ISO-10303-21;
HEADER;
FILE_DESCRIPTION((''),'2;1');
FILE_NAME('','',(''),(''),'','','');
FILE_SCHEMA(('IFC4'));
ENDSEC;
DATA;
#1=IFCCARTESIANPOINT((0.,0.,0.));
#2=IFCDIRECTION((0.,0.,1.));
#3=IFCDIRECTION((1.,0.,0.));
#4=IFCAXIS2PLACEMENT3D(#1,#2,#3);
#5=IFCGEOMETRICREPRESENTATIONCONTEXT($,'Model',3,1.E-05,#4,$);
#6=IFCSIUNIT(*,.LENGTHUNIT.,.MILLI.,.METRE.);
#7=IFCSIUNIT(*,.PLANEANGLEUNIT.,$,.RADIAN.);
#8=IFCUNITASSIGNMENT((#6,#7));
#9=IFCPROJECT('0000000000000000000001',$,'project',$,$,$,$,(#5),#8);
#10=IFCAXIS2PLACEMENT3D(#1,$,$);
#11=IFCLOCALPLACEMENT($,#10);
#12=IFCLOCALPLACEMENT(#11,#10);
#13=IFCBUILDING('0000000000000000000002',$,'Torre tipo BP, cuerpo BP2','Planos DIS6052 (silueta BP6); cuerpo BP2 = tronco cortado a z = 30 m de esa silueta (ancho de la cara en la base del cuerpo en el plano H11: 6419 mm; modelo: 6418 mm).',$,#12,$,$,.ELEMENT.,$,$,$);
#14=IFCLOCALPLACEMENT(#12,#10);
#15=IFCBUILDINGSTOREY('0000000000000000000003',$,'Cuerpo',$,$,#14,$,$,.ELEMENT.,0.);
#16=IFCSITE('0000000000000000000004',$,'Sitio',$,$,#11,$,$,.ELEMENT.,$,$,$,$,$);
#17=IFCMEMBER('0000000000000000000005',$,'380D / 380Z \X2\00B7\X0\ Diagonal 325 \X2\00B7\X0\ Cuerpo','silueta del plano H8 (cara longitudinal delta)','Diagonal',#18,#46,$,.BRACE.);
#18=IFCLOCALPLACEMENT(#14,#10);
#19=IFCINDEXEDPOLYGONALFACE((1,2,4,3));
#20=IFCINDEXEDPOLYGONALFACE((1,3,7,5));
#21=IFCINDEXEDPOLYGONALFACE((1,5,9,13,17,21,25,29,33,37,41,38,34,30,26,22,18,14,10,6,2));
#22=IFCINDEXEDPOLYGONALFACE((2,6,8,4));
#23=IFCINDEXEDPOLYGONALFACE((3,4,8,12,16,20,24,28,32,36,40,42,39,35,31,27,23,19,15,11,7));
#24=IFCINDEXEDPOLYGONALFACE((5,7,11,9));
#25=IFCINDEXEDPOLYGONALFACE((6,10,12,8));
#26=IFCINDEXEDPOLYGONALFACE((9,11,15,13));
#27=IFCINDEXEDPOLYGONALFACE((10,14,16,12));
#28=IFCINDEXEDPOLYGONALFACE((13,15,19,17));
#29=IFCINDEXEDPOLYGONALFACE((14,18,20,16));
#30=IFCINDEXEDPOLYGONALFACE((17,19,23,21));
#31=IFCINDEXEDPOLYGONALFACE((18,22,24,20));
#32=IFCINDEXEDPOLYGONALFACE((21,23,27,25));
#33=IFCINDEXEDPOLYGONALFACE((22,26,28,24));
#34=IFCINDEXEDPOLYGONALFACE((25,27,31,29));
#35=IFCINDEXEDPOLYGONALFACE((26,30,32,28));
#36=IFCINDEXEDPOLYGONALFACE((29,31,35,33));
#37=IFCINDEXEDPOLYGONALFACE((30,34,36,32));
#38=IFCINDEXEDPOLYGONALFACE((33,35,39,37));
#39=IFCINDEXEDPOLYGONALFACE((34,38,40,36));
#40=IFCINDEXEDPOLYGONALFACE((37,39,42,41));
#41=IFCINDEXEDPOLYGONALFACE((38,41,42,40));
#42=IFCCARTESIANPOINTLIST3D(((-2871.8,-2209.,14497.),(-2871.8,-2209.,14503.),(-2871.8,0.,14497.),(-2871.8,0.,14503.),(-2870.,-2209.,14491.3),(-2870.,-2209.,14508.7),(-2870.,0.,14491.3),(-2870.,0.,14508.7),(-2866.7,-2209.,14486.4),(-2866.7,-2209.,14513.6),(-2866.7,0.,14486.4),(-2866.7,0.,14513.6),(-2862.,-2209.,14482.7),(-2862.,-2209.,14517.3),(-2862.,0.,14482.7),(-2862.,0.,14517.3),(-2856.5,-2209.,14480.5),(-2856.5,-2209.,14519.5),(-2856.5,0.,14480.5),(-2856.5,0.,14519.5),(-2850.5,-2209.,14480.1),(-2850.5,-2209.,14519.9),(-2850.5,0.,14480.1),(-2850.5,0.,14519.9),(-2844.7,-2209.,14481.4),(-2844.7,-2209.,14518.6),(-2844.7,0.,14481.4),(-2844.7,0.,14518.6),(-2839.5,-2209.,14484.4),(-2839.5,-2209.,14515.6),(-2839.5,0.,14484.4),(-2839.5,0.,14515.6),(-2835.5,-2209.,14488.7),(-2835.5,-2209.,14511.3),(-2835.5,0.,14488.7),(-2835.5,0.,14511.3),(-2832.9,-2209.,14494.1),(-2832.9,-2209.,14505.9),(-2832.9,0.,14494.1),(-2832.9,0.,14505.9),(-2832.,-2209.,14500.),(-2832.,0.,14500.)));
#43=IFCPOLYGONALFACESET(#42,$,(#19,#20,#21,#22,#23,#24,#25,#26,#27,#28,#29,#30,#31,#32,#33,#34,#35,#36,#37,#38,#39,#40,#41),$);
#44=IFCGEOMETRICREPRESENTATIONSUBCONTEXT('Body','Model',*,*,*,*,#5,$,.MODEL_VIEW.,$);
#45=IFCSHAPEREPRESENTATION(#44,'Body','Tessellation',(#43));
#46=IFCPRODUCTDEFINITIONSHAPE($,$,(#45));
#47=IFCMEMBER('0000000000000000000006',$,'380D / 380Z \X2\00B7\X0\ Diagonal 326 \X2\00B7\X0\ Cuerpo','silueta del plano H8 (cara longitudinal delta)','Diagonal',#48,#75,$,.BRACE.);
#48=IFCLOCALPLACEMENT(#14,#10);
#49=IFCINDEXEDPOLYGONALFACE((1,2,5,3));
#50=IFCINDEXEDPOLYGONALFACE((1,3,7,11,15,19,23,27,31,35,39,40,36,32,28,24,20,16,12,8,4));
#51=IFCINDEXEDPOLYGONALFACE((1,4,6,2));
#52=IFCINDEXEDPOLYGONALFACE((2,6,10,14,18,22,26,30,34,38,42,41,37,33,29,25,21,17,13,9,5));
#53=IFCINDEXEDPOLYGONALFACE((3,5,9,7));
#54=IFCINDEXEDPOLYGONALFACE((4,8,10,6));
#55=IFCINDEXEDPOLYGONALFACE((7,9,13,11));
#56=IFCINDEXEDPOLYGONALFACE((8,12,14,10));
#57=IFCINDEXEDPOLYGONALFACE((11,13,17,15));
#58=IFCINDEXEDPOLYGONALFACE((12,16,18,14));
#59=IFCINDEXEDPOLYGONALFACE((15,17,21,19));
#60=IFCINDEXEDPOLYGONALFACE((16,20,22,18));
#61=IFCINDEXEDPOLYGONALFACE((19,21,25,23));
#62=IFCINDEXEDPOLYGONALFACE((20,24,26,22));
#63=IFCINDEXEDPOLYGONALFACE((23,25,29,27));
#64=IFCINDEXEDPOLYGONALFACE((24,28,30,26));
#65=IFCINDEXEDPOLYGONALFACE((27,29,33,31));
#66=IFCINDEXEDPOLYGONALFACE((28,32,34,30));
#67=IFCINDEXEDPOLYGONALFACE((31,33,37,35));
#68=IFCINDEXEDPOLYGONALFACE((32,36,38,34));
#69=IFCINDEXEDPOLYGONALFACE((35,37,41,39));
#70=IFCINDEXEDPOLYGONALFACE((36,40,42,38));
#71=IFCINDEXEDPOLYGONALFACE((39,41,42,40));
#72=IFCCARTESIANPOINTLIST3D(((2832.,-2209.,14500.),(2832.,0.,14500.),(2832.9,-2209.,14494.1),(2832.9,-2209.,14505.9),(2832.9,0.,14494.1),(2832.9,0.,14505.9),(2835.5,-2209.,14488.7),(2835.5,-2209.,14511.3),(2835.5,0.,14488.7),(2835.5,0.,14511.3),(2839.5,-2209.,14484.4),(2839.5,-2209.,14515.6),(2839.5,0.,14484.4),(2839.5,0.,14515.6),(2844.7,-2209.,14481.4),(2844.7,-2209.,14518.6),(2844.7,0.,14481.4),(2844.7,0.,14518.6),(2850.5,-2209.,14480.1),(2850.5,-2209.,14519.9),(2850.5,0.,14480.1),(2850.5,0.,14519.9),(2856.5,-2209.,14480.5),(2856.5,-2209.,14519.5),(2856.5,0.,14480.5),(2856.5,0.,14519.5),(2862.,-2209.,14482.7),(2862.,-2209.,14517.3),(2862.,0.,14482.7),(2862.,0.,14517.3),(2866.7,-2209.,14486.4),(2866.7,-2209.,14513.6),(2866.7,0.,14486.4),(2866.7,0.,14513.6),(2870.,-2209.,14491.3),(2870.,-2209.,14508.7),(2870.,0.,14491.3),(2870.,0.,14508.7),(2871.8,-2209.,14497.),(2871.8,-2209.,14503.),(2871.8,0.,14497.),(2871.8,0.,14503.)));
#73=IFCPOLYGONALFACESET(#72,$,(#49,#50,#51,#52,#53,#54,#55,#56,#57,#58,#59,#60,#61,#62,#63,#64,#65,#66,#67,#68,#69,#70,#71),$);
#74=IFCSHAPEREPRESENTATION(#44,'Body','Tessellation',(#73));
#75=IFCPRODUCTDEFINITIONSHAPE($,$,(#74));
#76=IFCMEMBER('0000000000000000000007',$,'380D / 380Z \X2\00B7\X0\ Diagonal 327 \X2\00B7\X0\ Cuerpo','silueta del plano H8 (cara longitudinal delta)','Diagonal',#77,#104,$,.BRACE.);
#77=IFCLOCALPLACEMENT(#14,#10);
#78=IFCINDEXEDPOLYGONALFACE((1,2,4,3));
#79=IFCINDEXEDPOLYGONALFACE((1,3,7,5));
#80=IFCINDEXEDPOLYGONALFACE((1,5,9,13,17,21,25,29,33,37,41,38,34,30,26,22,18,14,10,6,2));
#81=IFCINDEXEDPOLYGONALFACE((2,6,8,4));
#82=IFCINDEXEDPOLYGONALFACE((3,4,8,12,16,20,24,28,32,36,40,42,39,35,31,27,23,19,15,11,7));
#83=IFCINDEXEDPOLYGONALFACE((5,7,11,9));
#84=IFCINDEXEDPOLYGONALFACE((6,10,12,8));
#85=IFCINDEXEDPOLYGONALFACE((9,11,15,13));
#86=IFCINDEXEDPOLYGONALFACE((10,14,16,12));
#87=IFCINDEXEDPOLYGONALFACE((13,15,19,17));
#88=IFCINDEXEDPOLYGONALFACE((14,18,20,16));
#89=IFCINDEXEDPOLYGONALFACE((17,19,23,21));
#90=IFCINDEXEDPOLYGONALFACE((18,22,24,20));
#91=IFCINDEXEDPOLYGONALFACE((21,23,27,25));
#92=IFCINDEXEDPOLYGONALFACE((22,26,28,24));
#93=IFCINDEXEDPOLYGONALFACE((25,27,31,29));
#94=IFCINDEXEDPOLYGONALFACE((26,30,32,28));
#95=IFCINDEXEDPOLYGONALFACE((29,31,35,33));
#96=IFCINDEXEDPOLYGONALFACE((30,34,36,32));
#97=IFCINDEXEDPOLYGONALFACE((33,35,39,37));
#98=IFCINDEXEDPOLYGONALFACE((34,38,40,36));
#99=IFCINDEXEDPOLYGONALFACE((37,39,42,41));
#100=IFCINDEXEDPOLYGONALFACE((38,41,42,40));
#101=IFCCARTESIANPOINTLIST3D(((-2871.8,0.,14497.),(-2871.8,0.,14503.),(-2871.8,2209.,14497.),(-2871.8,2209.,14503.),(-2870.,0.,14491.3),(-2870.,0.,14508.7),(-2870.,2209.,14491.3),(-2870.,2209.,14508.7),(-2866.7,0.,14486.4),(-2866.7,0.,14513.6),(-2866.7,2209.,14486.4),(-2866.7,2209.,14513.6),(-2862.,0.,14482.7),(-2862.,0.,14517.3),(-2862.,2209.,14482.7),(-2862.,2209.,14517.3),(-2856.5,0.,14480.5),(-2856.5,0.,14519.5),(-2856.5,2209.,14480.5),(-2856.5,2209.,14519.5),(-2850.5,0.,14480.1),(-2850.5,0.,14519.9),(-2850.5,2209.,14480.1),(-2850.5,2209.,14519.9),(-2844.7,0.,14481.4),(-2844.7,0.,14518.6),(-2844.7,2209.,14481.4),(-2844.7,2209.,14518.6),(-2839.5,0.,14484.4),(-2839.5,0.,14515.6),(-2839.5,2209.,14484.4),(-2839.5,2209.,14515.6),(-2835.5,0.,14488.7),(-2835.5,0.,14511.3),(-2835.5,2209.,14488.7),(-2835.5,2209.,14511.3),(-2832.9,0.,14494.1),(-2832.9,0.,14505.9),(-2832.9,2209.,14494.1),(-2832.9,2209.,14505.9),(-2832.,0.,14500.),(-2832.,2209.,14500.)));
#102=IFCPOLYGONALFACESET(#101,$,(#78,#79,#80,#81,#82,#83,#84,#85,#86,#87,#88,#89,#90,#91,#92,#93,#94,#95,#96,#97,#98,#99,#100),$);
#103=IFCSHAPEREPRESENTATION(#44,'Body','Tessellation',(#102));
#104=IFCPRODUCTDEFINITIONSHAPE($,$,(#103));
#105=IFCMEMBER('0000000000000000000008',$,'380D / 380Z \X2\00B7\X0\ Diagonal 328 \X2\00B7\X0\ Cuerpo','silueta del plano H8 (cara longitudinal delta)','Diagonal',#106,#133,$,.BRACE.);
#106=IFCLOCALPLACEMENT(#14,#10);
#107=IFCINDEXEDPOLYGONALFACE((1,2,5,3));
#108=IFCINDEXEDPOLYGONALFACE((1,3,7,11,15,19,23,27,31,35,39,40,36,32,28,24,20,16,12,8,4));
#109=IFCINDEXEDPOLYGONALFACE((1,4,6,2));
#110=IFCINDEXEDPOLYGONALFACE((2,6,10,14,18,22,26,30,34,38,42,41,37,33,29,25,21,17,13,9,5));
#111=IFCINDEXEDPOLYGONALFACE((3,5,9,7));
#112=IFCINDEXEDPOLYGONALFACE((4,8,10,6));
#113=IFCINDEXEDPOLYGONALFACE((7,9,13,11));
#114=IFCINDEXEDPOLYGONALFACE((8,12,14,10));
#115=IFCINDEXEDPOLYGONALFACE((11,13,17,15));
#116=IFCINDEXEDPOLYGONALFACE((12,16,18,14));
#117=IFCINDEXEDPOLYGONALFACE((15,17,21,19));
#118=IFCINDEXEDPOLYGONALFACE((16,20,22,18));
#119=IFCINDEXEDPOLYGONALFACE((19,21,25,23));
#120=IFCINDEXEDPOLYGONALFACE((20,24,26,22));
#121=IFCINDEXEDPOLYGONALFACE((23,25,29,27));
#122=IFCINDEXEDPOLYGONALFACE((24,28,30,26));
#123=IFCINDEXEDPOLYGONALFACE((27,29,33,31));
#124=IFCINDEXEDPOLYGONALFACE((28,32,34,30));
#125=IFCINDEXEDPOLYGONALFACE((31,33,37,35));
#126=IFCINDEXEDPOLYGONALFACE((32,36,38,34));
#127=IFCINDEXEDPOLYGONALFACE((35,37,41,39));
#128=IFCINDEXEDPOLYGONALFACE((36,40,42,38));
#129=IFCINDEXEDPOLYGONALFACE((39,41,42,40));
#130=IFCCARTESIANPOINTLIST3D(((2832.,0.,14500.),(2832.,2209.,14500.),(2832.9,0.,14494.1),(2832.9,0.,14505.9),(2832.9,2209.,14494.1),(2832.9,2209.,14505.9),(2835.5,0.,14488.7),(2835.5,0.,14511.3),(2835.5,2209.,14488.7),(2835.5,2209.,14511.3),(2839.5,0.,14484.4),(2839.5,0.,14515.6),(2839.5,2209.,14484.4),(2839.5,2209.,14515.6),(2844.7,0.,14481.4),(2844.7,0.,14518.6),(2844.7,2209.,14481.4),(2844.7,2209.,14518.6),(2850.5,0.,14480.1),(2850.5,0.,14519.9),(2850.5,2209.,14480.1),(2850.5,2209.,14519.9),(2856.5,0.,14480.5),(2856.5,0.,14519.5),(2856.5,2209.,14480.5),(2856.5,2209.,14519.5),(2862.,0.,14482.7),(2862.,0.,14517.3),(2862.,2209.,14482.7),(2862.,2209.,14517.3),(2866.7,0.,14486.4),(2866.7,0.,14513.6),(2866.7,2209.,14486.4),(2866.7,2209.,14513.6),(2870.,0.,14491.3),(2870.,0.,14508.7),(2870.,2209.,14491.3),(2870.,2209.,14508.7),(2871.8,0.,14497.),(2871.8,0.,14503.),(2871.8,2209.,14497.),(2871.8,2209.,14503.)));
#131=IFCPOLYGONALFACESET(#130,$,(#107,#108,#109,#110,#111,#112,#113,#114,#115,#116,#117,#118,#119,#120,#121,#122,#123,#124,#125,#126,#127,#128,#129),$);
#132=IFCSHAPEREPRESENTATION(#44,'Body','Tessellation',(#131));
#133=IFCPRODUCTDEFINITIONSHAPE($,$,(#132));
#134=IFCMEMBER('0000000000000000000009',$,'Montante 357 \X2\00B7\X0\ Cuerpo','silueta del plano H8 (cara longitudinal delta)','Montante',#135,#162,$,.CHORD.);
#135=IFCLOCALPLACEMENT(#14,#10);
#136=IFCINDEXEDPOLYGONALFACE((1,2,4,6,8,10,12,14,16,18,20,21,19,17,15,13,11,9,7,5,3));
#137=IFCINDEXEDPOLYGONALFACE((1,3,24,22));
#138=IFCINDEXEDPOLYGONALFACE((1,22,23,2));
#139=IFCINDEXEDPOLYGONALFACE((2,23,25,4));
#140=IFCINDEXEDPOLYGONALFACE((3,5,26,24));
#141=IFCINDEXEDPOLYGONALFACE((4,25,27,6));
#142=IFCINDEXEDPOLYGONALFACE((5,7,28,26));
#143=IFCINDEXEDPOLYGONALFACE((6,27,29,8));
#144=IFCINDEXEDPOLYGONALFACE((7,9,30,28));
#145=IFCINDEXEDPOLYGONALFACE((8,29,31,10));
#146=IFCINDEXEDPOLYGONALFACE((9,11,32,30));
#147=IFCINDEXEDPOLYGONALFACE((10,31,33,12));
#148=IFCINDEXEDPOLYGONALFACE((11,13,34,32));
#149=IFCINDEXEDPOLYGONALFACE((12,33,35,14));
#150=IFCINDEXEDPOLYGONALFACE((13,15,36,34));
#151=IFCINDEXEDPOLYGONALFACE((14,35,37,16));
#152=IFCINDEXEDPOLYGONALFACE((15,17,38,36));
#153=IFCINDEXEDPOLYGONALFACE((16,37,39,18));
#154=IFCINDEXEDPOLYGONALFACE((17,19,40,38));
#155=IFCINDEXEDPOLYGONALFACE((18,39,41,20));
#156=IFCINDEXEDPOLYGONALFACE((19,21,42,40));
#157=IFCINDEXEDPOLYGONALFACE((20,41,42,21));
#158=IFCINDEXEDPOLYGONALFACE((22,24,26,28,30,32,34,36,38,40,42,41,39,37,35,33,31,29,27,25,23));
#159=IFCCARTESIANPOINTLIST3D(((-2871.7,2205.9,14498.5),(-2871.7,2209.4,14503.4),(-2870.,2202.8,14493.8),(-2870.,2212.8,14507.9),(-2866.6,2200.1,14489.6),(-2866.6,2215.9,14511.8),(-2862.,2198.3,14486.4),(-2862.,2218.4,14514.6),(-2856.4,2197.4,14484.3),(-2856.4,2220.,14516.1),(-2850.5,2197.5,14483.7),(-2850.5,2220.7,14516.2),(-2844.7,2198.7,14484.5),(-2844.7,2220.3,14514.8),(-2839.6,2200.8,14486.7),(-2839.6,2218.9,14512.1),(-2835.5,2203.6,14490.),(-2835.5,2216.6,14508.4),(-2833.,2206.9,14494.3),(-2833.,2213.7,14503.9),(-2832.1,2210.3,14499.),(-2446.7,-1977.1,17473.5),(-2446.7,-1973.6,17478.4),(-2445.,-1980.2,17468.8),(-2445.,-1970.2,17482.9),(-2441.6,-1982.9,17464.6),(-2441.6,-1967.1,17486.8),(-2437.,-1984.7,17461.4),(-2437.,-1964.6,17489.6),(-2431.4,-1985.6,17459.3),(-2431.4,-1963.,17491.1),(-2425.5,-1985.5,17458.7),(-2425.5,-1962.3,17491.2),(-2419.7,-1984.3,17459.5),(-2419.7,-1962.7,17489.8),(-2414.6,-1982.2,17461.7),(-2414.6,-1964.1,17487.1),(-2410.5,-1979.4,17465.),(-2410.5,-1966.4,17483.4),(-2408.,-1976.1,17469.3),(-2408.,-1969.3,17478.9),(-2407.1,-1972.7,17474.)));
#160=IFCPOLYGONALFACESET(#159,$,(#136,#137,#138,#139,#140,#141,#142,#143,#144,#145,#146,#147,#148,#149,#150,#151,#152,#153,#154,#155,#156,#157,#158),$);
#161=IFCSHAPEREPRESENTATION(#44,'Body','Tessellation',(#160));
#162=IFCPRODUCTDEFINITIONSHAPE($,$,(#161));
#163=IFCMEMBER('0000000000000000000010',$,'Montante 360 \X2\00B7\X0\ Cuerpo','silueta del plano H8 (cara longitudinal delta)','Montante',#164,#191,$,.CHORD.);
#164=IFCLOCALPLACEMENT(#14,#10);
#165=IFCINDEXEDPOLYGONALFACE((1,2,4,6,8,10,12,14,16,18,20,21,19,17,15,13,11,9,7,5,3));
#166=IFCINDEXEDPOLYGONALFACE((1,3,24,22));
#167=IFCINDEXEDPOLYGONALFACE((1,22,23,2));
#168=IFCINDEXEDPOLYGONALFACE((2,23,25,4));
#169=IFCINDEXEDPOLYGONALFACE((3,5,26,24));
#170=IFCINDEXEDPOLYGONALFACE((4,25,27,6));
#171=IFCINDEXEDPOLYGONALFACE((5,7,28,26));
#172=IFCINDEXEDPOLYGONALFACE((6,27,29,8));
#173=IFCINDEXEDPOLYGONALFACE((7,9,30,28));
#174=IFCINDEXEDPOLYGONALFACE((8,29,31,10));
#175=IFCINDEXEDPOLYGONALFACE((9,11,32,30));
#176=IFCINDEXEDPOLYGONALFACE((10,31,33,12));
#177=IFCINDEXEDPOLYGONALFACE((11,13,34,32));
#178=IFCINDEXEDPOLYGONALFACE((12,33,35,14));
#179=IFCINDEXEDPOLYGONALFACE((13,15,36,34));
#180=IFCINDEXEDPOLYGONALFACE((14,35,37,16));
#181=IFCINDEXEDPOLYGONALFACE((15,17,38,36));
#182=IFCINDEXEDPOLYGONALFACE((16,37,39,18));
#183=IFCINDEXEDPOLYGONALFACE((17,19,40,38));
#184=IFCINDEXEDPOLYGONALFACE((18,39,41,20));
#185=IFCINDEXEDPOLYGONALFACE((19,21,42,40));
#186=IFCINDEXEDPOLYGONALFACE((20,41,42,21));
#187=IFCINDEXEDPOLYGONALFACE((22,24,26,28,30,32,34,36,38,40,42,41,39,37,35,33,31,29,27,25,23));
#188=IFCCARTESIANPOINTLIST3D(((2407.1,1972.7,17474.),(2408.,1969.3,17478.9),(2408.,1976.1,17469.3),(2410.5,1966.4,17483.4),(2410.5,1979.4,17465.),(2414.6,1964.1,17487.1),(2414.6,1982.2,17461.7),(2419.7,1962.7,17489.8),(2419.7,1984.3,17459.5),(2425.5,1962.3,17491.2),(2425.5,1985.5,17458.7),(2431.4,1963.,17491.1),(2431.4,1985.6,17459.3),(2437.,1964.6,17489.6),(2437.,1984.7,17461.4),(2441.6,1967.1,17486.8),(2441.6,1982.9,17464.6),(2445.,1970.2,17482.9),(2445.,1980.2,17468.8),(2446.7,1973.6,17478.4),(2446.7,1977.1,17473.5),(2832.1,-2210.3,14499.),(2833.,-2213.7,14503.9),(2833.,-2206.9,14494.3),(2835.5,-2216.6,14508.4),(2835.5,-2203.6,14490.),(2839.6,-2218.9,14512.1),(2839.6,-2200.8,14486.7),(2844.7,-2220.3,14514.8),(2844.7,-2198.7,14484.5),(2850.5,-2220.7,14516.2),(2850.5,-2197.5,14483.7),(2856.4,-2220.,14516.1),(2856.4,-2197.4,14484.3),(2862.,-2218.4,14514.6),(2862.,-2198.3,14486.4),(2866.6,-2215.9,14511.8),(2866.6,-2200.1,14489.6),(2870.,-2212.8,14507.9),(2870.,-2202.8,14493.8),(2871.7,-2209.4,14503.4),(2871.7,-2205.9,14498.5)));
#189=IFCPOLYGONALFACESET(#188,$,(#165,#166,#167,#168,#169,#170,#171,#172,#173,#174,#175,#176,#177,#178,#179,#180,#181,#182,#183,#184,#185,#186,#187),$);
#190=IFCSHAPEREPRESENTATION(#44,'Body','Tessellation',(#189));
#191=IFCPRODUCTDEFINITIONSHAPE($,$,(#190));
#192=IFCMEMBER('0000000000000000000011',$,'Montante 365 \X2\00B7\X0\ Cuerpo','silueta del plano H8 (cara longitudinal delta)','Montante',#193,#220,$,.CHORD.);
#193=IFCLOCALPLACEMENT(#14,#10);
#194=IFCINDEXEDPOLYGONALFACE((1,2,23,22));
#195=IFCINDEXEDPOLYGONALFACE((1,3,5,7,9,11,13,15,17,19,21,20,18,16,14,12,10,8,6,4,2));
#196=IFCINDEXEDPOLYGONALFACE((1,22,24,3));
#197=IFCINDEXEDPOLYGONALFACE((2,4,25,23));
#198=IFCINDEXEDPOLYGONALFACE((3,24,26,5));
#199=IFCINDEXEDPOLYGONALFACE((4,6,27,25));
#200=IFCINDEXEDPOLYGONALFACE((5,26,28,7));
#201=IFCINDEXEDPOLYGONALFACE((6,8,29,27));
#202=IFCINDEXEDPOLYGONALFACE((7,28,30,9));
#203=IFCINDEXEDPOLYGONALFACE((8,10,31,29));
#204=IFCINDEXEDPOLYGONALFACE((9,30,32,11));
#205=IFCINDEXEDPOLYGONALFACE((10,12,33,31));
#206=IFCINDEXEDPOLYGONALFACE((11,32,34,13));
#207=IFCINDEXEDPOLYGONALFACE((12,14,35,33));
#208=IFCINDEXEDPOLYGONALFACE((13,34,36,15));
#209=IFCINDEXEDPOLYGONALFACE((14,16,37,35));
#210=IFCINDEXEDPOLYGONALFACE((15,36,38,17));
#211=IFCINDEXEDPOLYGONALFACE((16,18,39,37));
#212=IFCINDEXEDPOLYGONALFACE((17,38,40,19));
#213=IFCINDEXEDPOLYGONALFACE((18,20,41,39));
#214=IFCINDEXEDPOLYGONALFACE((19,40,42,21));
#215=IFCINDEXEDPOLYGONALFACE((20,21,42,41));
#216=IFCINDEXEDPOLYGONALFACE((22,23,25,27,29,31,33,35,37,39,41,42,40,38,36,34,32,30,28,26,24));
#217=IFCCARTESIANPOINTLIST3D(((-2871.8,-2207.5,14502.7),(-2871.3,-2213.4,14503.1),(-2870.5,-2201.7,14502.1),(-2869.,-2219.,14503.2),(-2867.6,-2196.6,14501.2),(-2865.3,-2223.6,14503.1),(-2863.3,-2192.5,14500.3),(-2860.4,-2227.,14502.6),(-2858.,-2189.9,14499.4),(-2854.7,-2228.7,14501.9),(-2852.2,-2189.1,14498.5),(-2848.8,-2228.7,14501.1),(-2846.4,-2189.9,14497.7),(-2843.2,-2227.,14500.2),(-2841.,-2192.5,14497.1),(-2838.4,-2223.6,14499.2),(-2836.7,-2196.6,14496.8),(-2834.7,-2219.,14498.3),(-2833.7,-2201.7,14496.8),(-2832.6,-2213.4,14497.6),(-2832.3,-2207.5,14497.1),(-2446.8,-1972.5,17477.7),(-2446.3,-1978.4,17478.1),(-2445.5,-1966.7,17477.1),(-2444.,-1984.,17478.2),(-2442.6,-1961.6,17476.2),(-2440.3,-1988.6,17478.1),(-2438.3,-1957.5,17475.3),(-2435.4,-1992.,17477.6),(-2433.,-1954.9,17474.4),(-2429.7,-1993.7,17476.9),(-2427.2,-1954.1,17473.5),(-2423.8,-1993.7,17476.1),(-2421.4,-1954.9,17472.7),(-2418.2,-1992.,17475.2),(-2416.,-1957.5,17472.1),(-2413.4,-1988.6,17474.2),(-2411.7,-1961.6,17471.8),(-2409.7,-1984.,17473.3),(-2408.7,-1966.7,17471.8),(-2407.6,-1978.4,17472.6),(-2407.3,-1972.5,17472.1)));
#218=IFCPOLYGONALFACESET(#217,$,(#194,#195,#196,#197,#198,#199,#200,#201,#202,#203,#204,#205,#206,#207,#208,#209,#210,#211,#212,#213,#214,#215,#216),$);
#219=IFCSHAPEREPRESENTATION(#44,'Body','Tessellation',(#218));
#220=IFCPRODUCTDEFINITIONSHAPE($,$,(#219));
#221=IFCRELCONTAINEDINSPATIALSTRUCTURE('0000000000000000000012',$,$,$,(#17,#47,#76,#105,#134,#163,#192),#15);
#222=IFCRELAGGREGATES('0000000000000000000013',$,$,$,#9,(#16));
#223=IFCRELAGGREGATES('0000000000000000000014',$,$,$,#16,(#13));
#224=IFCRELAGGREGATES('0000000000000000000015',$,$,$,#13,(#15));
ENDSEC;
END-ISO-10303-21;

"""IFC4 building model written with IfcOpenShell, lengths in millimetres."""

from ifc_helpers import new_model, si_unit, frame, origin, origin_with_axes, place, context, subcontext, project, spatial, circle, extrude, element, save


model = new_model("IFC4")

# Units and contexts
model_context = context("Model", 3, precision=1e-05, world=origin_with_axes())
body_context = subcontext(model_context, "Body", "Model", "MODEL_VIEW")
ifc_project = project(units=[si_unit("LENGTHUNIT", "METRE", prefix="MILLI"), si_unit("PLANEANGLEUNIT", "RADIAN")], contexts=[model_context])

# Site, building, storey
site_placement = place(None, origin())
site = spatial("IfcSite", under=ifc_project, at=site_placement, Name="Sitio", CompositionType="ELEMENT")
building_placement = place(site_placement, origin())
building = spatial("IfcBuilding", under=site, at=building_placement, Name="Torre tipo BP, cuerpo BP2", Description="Planos DIS6052 (silueta BP6); cuerpo BP2 = tronco cortado a z = 30 m de esa silueta (ancho de la cara en la base del cuerpo en el plano H11: 6419 mm; modelo: 6418 mm).", CompositionType="ELEMENT")
storey_placement = place(building_placement, origin())
storey = spatial("IfcBuildingStorey", under=building, at=storey_placement, Name="Cuerpo", CompositionType="ELEMENT", Elevation=0.0)

# Members
for number, where, z_axis, x_axis, name in (
    (1, (-2852.0, -2209.0, 14500.0), (0.0, 1.0, 0.0), (1.0, 0.0, 0.0), "380D / 380Z · Diagonal 325 · Cuerpo"),
    (2, (2852.0, -2209.0, 14500.0), (0.0, 1.0, 0.0), (-1.0, 0.0, 0.0), "380D / 380Z · Diagonal 326 · Cuerpo"),
    (3, (-2852.0, 2209.0, 14500.0), (0.0, -1.0, 0.0), (1.0, 0.0, 0.0), "380D / 380Z · Diagonal 327 · Cuerpo"),
    (4, (2852.0, 2209.0, 14500.0), (0.0, -1.0, 0.0), (-1.0, 0.0, 0.0), "380D / 380Z · Diagonal 328 · Cuerpo"),
):
    element("IfcMember", number, at=place(storey_placement, frame(where, z_axis=z_axis, x_axis=x_axis)), inside=storey, Name=name, Description="silueta del plano H8 (cara longitudinal delta)", ObjectType="Diagonal", PredefinedType="BRACE", context=body_context, shape_type="SweptSolid", body=[
        extrude(circle(Radius=20.0), None, (0.0, 0.0, 1.0), 2209.0),
    ])
for number, where, z_axis, x_axis, name in (
    (5, (-2427.0, -1974.0, 17475.0), (-0.082515, 0.812137, -0.577602), (0.99659, 0.067242, -0.047824), "Montante 357 · Cuerpo"),
    (6, (2427.0, 1974.0, 17475.0), (0.082515, -0.812137, -0.577602), (-0.99659, -0.067242, -0.047824), "Montante 360 · Cuerpo"),
):
    element("IfcMember", number, at=place(storey_placement, frame(where, z_axis=z_axis, x_axis=x_axis)), inside=storey, Name=name, Description="silueta del plano H8 (cara longitudinal delta)", ObjectType="Montante", PredefinedType="CHORD", context=body_context, shape_type="SweptSolid", body=[
        extrude(circle(Radius=20.0), None, (0.0, 0.0, 1.0), 5150.6),
    ])
for number, where, z_axis, x_axis, name in (
    (7, (-2427.0, -1974.0, 17475.0), (-0.140991, -0.07796, -0.986937), (-0.011025, 0.996957, -0.077176), "Montante 365 · Cuerpo"),
):
    element("IfcMember", number, at=place(storey_placement, frame(where, z_axis=z_axis, x_axis=x_axis)), inside=storey, Name=name, Description="silueta del plano H8 (cara longitudinal delta)", ObjectType="Montante", PredefinedType="CHORD", context=body_context, shape_type="SweptSolid", body=[
        extrude(circle(Radius=20.0), None, (0.0, 0.0, 1.0), 3014.4),
    ])

save(model, "model.ifc")
